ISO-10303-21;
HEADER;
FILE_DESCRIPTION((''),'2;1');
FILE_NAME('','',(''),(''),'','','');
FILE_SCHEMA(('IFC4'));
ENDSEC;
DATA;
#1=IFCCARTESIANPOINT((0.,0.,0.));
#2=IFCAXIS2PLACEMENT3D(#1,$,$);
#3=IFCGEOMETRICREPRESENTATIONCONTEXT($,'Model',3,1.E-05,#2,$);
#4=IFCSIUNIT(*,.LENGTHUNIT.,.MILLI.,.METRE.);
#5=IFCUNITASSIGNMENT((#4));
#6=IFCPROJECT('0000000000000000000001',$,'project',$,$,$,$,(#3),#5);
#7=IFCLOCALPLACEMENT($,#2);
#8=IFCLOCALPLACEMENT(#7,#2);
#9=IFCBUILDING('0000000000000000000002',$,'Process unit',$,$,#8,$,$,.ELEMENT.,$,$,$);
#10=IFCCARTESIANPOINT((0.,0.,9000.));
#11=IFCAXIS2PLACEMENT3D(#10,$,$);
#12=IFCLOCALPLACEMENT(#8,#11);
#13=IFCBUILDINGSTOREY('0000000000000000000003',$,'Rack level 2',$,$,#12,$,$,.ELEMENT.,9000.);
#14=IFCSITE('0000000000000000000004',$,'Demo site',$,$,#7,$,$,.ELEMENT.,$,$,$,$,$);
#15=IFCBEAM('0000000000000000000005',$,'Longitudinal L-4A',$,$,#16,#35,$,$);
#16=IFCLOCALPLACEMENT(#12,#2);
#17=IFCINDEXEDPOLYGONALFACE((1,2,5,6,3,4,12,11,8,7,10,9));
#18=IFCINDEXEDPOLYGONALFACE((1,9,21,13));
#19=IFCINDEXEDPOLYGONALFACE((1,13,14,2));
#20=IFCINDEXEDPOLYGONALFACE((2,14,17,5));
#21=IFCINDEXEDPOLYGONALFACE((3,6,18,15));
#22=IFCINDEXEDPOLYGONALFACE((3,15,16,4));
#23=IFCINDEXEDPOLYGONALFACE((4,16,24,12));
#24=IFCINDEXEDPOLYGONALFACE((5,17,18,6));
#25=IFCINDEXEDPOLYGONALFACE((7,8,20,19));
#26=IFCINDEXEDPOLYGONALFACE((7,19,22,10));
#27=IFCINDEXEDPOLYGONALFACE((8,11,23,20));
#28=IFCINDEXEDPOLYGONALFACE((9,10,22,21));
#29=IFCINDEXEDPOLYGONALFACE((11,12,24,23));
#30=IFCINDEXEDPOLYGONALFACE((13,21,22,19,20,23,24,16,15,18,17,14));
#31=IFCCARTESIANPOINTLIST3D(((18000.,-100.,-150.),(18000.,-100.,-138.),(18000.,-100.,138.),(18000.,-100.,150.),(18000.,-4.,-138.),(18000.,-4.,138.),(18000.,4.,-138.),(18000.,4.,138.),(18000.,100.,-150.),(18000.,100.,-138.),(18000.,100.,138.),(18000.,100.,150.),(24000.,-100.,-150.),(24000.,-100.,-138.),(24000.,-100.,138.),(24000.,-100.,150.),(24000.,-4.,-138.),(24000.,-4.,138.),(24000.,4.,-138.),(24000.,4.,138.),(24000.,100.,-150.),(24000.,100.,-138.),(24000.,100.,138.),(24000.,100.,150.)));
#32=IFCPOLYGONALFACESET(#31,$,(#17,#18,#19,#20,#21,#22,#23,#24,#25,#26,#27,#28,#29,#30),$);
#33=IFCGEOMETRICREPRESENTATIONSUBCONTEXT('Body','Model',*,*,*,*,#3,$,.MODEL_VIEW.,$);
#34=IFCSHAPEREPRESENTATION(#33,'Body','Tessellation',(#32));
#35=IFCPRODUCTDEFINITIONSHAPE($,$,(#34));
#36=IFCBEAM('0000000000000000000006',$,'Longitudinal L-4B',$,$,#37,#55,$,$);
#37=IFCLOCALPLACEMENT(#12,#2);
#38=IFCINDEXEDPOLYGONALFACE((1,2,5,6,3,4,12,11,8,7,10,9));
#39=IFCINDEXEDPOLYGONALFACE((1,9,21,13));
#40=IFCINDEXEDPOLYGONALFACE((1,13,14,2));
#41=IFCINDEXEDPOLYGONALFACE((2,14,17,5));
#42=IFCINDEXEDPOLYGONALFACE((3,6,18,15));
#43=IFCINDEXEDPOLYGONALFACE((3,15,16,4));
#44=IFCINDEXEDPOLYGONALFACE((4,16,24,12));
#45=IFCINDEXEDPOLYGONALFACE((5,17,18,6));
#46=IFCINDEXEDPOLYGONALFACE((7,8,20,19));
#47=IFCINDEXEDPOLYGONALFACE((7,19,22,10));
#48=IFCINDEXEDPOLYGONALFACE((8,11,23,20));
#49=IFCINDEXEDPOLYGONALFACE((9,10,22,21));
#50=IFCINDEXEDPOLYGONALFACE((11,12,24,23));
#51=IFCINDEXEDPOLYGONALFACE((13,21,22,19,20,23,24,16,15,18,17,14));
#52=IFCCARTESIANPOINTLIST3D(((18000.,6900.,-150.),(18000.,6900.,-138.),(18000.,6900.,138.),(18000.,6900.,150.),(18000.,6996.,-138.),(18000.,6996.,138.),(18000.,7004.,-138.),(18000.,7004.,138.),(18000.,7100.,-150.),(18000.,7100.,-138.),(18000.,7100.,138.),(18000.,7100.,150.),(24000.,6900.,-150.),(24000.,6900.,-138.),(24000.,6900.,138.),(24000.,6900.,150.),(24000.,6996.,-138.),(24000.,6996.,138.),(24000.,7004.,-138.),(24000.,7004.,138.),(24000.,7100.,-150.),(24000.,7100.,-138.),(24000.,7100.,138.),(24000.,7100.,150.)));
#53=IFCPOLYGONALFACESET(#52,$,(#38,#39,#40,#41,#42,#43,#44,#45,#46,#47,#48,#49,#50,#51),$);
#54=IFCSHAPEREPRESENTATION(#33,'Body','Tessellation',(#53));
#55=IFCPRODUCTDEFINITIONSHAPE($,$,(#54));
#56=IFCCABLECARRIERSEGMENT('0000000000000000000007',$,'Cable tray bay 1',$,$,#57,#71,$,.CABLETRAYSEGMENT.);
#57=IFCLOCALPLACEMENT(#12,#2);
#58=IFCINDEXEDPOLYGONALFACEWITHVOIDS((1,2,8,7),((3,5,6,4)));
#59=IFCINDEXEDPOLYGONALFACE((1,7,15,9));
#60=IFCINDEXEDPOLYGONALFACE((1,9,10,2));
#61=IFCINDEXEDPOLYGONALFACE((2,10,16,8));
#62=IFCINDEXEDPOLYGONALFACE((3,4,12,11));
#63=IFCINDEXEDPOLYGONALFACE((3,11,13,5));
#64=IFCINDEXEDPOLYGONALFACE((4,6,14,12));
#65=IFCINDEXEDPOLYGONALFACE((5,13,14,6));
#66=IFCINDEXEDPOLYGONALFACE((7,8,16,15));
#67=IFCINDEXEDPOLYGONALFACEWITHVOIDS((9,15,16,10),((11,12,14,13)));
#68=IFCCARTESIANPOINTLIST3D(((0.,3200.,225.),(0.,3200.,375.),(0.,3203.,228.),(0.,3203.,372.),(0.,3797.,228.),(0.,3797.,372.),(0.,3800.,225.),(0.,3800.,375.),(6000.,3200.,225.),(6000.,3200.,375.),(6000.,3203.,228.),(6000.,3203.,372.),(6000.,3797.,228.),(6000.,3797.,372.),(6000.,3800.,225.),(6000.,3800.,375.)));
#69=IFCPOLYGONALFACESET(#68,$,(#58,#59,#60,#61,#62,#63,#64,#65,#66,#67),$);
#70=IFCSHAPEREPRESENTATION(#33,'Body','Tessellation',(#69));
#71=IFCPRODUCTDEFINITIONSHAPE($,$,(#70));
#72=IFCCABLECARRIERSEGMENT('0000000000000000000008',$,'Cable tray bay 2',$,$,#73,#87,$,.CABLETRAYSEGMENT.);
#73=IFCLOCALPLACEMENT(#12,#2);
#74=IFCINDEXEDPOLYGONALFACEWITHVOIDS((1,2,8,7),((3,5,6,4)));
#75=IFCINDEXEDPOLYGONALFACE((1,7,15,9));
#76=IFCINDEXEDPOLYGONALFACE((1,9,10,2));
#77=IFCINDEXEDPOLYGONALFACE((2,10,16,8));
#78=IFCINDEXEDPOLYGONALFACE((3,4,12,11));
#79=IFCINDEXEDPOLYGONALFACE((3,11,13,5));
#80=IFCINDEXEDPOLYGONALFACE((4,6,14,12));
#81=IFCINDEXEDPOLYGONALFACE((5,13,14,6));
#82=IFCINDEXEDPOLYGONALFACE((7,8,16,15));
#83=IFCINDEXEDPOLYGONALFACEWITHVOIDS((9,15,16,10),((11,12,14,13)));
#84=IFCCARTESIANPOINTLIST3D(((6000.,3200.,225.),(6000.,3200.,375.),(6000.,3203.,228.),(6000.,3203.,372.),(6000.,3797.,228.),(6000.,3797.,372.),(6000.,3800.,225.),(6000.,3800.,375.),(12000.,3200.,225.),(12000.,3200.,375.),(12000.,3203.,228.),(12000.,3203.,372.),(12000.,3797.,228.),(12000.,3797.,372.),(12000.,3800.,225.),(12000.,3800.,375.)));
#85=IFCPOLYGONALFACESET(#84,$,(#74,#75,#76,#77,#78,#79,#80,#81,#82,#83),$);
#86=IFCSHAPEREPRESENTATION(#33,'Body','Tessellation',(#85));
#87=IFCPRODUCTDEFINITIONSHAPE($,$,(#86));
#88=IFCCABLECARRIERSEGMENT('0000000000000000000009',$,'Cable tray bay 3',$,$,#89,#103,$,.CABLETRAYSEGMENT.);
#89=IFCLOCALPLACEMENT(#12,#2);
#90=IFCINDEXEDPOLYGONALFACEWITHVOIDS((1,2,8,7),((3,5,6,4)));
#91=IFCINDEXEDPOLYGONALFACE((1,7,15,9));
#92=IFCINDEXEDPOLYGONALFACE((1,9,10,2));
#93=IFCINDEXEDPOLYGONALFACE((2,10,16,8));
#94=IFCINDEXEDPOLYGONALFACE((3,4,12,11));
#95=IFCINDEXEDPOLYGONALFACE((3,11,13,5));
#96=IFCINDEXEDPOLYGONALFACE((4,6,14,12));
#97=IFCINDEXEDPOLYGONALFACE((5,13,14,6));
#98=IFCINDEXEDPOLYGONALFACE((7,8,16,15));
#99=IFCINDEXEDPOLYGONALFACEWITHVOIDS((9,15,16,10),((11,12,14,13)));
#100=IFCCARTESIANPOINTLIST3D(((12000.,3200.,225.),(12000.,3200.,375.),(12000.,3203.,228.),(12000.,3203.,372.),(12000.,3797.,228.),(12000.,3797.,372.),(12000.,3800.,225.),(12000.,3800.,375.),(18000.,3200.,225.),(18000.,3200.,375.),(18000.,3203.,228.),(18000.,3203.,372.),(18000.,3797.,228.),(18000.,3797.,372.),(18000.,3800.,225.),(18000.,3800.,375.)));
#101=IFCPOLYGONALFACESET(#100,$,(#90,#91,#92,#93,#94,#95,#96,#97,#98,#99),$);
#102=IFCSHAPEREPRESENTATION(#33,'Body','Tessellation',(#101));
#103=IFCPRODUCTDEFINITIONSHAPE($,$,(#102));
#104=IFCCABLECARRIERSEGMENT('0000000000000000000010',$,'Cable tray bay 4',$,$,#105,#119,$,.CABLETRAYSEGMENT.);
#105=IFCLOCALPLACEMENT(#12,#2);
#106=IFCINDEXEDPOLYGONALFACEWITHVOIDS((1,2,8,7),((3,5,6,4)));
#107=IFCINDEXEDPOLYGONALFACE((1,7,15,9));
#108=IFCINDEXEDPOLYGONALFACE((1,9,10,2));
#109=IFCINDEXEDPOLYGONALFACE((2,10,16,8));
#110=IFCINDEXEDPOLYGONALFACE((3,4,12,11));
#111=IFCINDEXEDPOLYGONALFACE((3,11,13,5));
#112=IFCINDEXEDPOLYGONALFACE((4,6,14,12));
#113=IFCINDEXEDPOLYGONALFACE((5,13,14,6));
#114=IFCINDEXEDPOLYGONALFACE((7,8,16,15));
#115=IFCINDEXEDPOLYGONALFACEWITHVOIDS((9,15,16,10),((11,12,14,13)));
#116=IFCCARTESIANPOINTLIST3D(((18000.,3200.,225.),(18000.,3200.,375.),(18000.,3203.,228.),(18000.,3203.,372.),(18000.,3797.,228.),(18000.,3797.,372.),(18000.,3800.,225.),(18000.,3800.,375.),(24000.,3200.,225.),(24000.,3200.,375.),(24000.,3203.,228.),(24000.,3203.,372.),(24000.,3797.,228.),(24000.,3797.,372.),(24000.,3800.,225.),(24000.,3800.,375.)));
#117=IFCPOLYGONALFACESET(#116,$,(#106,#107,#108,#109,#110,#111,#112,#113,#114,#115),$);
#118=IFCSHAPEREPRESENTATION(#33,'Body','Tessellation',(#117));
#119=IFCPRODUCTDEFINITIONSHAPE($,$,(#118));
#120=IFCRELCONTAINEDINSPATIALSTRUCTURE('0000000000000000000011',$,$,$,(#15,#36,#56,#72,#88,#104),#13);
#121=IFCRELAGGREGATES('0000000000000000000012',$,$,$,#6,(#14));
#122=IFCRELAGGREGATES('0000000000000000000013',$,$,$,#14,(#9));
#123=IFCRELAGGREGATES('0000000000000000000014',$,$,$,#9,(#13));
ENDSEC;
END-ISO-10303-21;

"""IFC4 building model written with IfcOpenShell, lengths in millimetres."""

from ifc_helpers import new_model, si_unit, frame, origin, place, context, subcontext, project, spatial, hollow_rectangle, i_section, extrude, element, save


model = new_model("IFC4")

# Units and contexts
model_context = context("Model", 3, precision=1e-05, world=origin())
body_context = subcontext(model_context, "Body", "Model", "MODEL_VIEW")
ifc_project = project(units=[si_unit("LENGTHUNIT", "METRE", prefix="MILLI")], contexts=[model_context])

# Site, building, storey
site_placement = place(None, origin())
site = spatial("IfcSite", under=ifc_project, at=site_placement, Name="Demo site", CompositionType="ELEMENT")
building_placement = place(site_placement, origin())
building = spatial("IfcBuilding", under=site, at=building_placement, Name="Process unit", CompositionType="ELEMENT")
storey_placement = place(building_placement, frame((0.0, 0.0, 9000.0)))
storey = spatial("IfcBuildingStorey", under=building, at=storey_placement, Name="Rack level 2", CompositionType="ELEMENT", Elevation=9000.0)

# Beams
for number, where, name in (
    (1, (18000.0, 0.0, 0.0), "Longitudinal L-4A"),
    (2, (18000.0, 7000.0, 0.0), "Longitudinal L-4B"),
):
    element("IfcBeam", number, at=place(storey_placement, frame(where)), inside=storey, Name=name, context=body_context, shape_type="SweptSolid", body=[
        extrude(i_section(OverallWidth=200.0, OverallDepth=300.0, WebThickness=8.0, FlangeThickness=12.0), frame((0.0, 0.0, 0.0), z_axis=(1.0, 0.0, 0.0), x_axis=(0.0, 1.0, 0.0)), (0.0, 0.0, 1.0), 6000.0),
    ])

# Cable carrier segments
for number, where, name in (
    (3, (0.0, 3500.0, 300.0), "Cable tray bay 1"),
    (4, (6000.0, 3500.0, 300.0), "Cable tray bay 2"),
    (5, (12000.0, 3500.0, 300.0), "Cable tray bay 3"),
    (6, (18000.0, 3500.0, 300.0), "Cable tray bay 4"),
):
    element("IfcCableCarrierSegment", number, at=place(storey_placement, frame(where)), inside=storey, Name=name, PredefinedType="CABLETRAYSEGMENT", context=body_context, shape_type="SweptSolid", body=[
        extrude(hollow_rectangle(XDim=600.0, YDim=150.0, WallThickness=3.0), frame((0.0, 0.0, 0.0), z_axis=(1.0, 0.0, 0.0), x_axis=(0.0, 1.0, 0.0)), (0.0, 0.0, 1.0), 6000.0),
    ])

save(model, "model.ifc")
